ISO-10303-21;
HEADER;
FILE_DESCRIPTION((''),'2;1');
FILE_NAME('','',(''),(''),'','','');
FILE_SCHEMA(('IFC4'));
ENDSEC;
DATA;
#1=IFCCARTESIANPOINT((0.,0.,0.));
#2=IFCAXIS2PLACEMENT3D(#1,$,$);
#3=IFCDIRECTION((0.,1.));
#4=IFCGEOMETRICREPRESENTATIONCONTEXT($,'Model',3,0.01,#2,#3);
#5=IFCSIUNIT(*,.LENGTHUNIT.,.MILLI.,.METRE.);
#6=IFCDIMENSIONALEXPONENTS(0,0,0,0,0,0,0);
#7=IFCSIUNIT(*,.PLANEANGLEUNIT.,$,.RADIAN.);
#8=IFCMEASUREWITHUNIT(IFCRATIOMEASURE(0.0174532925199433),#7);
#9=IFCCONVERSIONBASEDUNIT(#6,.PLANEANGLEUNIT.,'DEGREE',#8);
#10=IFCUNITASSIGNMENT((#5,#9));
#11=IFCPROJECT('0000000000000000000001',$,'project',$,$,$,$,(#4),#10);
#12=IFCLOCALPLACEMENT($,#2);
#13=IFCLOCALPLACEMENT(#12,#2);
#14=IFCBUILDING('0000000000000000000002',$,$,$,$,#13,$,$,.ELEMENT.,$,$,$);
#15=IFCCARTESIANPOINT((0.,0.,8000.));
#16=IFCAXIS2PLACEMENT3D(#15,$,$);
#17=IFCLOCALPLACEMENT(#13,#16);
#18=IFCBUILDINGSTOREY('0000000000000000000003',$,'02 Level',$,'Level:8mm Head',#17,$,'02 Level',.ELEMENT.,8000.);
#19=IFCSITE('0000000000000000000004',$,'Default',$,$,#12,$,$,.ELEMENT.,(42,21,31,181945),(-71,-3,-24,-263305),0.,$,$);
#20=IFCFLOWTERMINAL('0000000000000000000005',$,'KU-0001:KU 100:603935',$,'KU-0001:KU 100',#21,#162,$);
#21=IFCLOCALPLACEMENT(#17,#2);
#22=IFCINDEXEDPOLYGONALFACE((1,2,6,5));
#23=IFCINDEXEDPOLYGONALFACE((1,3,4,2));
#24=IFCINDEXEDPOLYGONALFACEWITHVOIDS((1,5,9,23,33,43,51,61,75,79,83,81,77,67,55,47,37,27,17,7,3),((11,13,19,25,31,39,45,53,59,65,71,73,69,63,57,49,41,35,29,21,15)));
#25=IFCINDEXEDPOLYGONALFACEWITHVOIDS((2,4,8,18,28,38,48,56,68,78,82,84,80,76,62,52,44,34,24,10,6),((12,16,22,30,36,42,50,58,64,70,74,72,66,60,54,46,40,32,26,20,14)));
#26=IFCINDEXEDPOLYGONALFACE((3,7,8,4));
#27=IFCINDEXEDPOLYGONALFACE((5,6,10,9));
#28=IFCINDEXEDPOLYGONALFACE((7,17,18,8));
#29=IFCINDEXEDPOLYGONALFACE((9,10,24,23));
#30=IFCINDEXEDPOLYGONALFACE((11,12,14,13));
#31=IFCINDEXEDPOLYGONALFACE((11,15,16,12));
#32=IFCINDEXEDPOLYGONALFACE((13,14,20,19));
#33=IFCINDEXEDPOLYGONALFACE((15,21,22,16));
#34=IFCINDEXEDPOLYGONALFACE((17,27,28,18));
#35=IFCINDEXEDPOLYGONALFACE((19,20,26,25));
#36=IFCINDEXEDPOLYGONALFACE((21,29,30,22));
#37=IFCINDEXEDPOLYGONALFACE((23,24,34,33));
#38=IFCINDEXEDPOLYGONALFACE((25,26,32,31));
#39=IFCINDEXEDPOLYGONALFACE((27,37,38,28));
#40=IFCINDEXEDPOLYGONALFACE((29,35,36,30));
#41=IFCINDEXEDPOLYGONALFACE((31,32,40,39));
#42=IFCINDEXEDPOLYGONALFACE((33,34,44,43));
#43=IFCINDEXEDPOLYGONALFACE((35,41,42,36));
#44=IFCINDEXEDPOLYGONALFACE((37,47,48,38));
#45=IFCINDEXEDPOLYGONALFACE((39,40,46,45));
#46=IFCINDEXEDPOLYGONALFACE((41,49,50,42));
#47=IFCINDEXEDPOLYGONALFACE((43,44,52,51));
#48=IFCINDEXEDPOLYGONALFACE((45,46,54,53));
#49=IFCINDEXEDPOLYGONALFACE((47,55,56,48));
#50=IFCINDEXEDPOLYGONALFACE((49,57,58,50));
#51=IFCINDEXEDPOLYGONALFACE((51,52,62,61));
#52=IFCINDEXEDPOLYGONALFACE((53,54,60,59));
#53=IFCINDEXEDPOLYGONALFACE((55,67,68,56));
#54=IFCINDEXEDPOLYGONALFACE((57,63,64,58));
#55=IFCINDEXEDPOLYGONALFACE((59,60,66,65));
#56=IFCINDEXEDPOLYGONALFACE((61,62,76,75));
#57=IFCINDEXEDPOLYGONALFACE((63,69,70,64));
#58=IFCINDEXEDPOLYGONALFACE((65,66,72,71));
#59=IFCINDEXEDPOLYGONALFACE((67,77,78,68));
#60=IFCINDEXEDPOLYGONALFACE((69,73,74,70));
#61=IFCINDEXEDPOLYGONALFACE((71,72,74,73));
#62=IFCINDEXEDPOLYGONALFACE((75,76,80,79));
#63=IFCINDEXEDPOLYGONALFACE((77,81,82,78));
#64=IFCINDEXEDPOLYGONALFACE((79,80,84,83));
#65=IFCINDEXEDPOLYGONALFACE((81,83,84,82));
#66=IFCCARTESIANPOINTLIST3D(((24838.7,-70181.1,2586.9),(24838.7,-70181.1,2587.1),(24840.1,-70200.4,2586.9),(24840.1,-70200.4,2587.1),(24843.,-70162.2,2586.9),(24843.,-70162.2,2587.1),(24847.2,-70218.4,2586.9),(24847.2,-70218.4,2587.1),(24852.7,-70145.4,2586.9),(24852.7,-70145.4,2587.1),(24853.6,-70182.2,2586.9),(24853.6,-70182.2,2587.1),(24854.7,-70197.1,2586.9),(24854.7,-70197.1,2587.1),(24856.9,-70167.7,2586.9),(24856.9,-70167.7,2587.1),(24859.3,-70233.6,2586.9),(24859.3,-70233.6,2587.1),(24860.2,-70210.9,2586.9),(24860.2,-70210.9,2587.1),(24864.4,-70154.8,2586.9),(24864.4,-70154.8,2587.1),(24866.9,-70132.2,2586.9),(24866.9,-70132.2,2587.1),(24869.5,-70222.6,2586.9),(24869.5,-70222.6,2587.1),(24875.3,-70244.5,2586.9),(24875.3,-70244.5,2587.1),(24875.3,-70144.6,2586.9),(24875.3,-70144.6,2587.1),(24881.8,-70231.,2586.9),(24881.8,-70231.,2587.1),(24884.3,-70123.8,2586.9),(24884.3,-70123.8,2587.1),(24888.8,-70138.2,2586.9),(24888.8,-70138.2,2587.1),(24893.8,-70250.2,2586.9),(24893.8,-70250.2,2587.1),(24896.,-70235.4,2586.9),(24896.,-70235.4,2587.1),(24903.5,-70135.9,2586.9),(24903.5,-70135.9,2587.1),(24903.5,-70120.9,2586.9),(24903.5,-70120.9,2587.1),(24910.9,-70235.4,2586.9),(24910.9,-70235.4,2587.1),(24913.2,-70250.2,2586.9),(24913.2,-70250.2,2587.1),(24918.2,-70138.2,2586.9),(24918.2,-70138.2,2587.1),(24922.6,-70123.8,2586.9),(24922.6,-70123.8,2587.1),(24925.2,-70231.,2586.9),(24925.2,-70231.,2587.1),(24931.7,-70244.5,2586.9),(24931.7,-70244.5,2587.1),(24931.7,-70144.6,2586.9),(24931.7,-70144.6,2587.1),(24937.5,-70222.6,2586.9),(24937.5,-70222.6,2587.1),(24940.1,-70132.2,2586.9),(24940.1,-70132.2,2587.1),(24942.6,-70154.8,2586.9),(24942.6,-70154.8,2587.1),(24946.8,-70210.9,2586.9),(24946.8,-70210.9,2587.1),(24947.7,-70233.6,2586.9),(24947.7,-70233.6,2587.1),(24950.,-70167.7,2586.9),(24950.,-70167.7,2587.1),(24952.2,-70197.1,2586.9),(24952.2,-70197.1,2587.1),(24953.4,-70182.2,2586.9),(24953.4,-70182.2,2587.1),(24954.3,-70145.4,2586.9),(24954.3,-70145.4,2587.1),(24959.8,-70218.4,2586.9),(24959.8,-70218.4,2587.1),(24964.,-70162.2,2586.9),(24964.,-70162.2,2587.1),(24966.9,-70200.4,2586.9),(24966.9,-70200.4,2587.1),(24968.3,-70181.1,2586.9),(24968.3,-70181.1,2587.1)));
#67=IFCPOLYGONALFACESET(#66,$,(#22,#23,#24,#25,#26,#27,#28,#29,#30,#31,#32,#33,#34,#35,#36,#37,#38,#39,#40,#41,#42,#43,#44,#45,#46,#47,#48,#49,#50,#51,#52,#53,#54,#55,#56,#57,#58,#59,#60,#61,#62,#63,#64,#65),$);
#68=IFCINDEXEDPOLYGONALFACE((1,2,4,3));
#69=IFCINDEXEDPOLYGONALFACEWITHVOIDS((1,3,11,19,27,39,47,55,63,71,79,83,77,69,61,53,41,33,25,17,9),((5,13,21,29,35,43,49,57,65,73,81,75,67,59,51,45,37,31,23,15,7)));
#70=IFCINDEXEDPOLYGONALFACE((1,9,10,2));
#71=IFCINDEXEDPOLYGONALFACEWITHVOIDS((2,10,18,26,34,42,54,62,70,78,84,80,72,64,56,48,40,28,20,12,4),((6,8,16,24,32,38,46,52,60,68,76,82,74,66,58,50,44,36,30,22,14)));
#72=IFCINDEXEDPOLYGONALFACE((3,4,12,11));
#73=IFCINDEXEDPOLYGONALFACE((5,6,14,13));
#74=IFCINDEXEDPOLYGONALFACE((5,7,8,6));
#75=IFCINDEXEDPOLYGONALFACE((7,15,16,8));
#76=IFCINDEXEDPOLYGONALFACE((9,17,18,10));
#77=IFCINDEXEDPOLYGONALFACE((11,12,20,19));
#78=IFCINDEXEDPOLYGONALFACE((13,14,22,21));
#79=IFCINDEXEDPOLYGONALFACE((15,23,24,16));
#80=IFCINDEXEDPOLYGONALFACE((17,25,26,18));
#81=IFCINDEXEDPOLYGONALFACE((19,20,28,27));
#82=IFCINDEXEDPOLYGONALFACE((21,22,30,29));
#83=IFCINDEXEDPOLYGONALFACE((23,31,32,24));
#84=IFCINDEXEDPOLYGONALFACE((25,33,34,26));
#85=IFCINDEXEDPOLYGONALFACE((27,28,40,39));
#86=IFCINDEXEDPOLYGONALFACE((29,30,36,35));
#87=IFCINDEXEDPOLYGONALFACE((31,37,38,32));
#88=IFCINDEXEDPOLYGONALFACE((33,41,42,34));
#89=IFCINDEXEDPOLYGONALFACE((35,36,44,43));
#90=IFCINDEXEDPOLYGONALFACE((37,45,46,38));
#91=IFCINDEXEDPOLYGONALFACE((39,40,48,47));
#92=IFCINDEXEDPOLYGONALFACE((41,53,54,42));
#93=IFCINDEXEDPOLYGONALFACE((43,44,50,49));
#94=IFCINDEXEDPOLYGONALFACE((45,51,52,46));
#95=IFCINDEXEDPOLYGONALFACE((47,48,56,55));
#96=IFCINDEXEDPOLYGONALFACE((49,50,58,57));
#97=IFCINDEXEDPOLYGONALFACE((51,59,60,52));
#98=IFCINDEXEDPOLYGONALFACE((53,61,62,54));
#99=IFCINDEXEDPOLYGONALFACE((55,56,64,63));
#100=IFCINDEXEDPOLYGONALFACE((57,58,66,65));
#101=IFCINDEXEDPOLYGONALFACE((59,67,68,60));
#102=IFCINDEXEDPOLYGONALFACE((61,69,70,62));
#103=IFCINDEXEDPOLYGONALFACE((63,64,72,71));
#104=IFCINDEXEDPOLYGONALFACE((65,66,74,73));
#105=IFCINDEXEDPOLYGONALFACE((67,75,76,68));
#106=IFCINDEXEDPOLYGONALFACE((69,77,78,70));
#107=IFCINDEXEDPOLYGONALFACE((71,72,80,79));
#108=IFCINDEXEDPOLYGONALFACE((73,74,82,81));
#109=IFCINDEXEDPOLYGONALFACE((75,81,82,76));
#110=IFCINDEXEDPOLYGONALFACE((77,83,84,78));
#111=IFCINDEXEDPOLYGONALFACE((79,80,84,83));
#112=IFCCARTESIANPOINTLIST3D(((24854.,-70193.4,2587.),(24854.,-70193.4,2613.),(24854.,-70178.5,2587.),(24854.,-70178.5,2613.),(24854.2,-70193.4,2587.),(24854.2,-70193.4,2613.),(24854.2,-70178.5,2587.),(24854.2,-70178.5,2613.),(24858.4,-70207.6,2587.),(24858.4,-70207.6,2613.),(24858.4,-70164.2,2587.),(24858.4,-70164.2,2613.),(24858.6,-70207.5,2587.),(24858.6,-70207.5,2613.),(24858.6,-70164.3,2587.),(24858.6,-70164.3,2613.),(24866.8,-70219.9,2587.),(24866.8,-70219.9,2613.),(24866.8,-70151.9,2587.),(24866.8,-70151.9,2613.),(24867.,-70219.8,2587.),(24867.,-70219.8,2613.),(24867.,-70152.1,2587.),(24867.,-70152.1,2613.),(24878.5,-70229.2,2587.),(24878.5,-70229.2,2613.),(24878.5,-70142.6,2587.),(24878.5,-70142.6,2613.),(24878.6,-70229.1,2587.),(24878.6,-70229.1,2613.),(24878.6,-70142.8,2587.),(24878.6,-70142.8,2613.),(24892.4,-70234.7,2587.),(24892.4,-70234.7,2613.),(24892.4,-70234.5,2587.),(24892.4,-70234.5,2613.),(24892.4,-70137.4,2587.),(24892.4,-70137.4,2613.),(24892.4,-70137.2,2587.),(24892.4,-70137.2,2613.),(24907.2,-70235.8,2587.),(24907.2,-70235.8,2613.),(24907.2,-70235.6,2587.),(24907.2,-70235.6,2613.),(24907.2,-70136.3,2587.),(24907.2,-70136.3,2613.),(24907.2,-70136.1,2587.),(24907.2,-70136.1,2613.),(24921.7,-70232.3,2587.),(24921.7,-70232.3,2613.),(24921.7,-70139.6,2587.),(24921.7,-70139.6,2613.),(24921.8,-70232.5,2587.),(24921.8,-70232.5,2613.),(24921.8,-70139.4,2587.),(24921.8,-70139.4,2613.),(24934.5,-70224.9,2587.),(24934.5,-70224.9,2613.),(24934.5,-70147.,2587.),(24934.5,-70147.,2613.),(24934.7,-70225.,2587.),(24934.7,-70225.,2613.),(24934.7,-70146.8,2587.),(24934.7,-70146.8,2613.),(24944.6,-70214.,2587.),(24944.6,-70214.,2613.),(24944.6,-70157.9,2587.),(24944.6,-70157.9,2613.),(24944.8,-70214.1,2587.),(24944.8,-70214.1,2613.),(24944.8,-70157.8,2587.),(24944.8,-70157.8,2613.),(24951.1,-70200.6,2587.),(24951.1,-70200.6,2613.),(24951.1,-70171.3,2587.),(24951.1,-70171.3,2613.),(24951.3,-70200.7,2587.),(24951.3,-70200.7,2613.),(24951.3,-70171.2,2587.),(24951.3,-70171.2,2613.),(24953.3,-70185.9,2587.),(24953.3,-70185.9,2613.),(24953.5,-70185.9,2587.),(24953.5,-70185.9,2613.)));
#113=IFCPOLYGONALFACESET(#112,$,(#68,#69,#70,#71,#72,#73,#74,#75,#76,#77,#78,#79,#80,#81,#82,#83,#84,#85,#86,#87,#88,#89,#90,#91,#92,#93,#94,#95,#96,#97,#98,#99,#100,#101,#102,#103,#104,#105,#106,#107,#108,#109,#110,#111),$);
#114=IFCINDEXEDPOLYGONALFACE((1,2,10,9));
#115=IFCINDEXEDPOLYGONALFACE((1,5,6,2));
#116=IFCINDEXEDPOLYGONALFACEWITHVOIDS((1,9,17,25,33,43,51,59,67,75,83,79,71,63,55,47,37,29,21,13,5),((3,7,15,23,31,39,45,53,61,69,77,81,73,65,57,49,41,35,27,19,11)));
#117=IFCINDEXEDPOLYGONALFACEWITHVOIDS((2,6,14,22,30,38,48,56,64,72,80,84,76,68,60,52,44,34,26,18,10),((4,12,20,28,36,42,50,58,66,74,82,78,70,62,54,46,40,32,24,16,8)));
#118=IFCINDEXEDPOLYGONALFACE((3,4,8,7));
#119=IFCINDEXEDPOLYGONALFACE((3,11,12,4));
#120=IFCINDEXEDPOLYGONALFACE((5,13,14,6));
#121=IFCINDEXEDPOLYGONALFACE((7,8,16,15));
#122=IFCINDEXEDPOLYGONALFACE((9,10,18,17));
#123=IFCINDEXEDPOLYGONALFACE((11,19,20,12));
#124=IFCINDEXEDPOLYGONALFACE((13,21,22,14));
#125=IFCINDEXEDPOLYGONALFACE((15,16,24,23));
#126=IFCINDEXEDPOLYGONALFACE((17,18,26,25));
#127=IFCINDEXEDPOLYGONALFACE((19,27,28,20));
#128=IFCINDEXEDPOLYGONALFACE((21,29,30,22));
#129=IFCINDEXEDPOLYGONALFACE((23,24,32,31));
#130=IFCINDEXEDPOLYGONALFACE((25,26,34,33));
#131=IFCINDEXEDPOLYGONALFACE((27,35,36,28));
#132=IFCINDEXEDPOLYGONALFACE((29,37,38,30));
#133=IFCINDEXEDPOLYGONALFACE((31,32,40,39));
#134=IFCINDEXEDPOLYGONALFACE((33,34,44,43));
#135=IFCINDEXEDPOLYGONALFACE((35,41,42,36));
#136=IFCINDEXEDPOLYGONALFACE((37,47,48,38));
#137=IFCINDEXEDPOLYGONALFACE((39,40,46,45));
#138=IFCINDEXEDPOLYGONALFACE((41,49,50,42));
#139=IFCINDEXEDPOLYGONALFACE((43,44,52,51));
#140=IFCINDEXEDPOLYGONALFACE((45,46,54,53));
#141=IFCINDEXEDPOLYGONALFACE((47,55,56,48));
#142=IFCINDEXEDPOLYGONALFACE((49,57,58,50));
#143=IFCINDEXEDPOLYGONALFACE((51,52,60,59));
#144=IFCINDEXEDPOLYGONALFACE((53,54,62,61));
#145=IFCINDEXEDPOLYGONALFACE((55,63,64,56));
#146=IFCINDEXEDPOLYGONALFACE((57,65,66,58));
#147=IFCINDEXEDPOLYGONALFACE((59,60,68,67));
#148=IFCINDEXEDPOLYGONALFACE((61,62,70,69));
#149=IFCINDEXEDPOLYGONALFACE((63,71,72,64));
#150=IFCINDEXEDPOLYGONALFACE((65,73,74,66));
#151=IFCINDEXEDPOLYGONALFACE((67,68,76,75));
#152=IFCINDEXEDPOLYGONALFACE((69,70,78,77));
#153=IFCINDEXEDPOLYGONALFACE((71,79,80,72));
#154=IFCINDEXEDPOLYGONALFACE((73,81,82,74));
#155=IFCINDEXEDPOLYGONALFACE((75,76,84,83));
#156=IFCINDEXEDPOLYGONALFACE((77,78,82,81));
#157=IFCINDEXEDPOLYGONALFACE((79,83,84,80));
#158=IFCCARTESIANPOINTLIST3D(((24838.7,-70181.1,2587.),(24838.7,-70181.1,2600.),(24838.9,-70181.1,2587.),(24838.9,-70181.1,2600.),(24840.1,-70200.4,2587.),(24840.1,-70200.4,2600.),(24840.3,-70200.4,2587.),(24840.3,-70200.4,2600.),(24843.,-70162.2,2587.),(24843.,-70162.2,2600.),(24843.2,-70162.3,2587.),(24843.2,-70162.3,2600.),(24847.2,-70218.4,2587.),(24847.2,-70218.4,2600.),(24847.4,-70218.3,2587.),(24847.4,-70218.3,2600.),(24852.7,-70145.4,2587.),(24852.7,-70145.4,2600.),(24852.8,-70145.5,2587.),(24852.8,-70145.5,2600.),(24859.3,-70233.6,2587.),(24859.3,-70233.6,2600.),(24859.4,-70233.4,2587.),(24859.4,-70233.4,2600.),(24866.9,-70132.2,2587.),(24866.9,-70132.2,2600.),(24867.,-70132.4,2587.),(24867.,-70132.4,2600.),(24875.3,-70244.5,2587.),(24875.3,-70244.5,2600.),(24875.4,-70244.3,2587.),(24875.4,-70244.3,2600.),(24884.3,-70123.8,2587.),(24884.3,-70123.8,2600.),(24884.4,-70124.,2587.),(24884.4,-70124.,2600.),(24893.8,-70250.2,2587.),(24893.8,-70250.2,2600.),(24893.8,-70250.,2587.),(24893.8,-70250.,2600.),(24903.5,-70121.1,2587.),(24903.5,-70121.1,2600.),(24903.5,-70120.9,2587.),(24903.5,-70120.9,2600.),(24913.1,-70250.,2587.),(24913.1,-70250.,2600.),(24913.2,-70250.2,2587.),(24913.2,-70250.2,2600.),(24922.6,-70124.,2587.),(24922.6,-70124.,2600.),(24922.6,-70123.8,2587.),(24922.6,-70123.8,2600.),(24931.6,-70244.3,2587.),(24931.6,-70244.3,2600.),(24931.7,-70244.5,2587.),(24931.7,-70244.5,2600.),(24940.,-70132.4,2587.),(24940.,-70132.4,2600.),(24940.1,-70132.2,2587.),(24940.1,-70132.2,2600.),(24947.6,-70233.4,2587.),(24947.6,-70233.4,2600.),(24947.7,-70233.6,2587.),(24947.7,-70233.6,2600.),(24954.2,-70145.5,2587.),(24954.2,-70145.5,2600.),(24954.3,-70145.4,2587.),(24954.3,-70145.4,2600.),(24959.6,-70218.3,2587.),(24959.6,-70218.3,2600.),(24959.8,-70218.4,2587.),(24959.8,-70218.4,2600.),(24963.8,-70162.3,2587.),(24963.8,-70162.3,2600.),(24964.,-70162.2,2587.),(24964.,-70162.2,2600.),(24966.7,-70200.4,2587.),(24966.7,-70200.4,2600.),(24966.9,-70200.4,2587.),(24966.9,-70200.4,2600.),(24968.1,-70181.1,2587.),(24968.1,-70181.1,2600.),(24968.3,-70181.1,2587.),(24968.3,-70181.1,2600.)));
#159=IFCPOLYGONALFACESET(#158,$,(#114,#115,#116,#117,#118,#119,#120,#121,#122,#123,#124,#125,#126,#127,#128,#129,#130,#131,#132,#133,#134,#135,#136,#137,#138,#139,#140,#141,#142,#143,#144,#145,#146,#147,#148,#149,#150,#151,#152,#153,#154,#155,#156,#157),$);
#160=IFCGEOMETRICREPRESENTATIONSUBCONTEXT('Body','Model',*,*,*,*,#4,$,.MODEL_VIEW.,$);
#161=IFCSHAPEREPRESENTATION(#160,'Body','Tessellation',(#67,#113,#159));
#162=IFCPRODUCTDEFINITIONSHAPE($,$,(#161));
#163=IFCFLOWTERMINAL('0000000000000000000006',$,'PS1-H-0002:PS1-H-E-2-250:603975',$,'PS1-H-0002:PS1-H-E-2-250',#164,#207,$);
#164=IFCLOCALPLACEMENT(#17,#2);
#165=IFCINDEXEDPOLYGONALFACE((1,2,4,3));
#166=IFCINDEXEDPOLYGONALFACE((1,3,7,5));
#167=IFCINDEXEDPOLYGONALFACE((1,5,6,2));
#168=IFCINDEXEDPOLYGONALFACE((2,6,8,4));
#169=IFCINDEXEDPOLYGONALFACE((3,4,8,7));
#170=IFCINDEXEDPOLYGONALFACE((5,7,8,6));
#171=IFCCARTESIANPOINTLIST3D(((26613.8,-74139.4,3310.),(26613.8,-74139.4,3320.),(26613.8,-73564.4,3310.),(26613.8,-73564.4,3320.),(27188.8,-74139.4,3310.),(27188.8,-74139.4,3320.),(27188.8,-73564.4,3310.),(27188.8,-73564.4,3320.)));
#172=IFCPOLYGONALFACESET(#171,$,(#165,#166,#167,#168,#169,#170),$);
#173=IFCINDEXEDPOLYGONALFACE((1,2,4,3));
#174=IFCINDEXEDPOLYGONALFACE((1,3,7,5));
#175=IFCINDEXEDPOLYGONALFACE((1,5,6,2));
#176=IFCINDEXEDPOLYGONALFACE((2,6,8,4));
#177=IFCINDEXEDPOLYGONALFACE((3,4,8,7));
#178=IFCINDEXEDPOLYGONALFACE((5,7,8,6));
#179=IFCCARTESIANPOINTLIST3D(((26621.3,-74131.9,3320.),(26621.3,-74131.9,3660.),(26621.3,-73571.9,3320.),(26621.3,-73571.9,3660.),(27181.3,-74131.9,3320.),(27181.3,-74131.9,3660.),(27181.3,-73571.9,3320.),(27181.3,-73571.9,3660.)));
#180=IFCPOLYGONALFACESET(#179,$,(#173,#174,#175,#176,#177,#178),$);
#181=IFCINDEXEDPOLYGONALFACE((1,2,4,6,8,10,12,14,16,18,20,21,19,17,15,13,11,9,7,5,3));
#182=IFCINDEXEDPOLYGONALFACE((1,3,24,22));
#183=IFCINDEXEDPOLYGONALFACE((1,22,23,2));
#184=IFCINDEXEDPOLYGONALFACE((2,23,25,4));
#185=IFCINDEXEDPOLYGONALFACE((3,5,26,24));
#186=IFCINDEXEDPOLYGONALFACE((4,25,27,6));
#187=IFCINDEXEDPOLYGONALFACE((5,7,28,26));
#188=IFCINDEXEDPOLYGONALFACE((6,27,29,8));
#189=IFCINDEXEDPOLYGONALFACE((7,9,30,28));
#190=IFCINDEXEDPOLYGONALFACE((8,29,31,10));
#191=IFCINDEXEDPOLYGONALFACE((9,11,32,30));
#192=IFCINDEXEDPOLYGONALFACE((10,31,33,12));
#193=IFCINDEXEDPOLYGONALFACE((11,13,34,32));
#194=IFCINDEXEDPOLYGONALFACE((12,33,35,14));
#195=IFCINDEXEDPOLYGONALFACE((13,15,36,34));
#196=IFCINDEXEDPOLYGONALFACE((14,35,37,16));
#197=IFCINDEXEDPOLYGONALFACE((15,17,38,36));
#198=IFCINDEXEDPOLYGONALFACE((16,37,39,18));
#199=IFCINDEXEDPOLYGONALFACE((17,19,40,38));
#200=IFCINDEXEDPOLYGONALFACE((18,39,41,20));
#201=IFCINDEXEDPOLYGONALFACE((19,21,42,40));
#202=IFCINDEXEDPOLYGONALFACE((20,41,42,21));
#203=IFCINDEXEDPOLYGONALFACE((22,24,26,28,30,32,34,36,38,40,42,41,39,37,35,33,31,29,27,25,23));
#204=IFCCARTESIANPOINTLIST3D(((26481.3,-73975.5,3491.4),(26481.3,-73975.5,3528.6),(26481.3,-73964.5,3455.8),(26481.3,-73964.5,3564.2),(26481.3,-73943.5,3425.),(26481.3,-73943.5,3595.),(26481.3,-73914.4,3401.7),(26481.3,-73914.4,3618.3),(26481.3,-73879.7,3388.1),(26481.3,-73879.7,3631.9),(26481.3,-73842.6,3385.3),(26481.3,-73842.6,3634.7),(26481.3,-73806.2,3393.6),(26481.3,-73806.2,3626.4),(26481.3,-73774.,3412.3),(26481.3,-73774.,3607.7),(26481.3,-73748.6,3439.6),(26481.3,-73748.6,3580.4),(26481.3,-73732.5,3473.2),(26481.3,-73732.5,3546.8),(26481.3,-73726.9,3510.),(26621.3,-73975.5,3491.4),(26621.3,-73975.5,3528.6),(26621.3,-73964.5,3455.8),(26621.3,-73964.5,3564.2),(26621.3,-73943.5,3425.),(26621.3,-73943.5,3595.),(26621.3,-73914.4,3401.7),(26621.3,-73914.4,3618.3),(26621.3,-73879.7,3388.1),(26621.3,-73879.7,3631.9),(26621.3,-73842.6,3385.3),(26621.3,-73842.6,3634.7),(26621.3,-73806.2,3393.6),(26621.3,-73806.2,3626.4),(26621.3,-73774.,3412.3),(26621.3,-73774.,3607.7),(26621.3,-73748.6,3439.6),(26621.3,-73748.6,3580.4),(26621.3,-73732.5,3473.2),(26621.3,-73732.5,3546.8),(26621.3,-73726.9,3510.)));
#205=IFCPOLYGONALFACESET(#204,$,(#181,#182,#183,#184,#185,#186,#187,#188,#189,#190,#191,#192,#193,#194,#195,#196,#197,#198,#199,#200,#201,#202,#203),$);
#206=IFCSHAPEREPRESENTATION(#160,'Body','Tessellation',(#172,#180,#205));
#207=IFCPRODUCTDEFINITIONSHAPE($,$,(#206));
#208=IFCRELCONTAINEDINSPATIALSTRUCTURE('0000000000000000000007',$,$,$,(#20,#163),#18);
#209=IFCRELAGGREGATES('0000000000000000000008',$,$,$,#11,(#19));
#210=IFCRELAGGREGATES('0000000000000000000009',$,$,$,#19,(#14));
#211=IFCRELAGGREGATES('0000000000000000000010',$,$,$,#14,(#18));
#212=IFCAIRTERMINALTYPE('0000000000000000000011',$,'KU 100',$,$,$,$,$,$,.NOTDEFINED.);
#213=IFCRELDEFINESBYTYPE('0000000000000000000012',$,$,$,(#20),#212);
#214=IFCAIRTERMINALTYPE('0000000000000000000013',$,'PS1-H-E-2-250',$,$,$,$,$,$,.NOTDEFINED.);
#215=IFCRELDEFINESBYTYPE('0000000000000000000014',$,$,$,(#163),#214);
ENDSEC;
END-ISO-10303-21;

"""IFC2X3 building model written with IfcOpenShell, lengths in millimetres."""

from ifc_helpers import new_model, entity, si_unit, converted_unit, direction, frame, frame_2d, origin, origin_2d_with_axis, place, context, subcontext, project, spatial, rectangle, circle, hollow_circle, extrude, source, transform, mapped, type_object, type_shapes, element, save


model = new_model("IFC2X3")

# Units and contexts
model_context = context("Model", 3, precision=0.01, world=origin(), true_north=direction((0.0, 1.0)))
body_context = subcontext(model_context, "Body", "Model", "MODEL_VIEW")
ifc_project = project(units=[si_unit("LENGTHUNIT", "METRE", prefix="MILLI"), converted_unit("PLANEANGLEUNIT", "DEGREE", entity("IfcRatioMeasure", 0.0174532925199433), si_unit("PLANEANGLEUNIT", "RADIAN"), dimensions=[0, 0, 0, 0, 0, 0, 0])], contexts=[model_context])

# Site, building, storey
site_placement = place(None, origin())
site = spatial("IfcSite", under=ifc_project, at=site_placement, Name="Default", CompositionType="ELEMENT", RefLatitude=(42, 21, 31, 181945), RefLongitude=(-71, -3, -24, -263305), RefElevation=0.0)
building_placement = place(site_placement, origin())
building = spatial("IfcBuilding", under=site, at=building_placement, CompositionType="ELEMENT")
storey_placement = place(building_placement, frame((0.0, 0.0, 8000.0)))
storey = spatial("IfcBuildingStorey", under=building, at=storey_placement, Name="02 Level", ObjectType="Level:8mm Head", LongName="02 Level", CompositionType="ELEMENT", Elevation=8000.0)

# Flow terminals
air_terminal_type_1 = type_object("IfcAirTerminalType", Name="KU 100", PredefinedType="NOTDEFINED")
shared_shape_1 = source(origin(), body_context, "Body", "SweptSolid", [
    extrude(hollow_circle(Radius=65.0, WallThickness=15.0, at=frame_2d((0.0, 0.0), x_axis=(1.0, 0.0))), frame((12.9, 0.0, 0.0), z_axis=(1.0, 0.0, 0.0), x_axis=(0.0, 1.0, 0.0)), (0.0, 0.0, 1.0), 0.2),
    extrude(hollow_circle(Radius=50.0, WallThickness=0.2, at=frame_2d((0.0, 0.0), x_axis=(1.0, 0.0))), frame((-13.0, 0.0, 0.0), z_axis=(1.0, 0.0, 0.0), x_axis=(0.0, 0.0, 1.0)), (0.0, 0.0, 1.0), 26.0),
    extrude(hollow_circle(Radius=65.0, WallThickness=0.2, at=frame_2d((0.0, 0.0), x_axis=(1.0, 0.0))), frame((0.0, 0.0, 0.0), z_axis=(1.0, 0.0, 0.0), x_axis=(0.0, 1.0, 0.0)), (0.0, 0.0, 1.0), 13.0),
])
type_shapes(air_terminal_type_1, [shared_shape_1])
flow_terminal_1_placement = place(storey_placement, frame((24903.5, -70185.9, 2600.0), z_axis=(1.0, 0.0, 0.0), x_axis=(0.0, 0.0, -1.0)))
element("IfcFlowTerminal", 1, at=flow_terminal_1_placement, inside=storey, type_object=air_terminal_type_1, Name="KU-0001:KU 100:603935", ObjectType="KU-0001:KU 100", context=body_context, shape_type="MappedRepresentation", body=[
    mapped(shared_shape_1, transform((0.0, 0.0, 0.0), scale=1.0)),
])
air_terminal_type_2 = type_object("IfcAirTerminalType", Name="PS1-H-E-2-250", PredefinedType="NOTDEFINED")
shared_shape_2 = source(origin(), body_context, "Body", "SweptSolid", [
    extrude(rectangle(XDim=575.0, YDim=575.0, at=origin_2d_with_axis()), frame((0.0, 0.0, -10.0), z_axis=(0.0, 0.0, 1.0), x_axis=(-1.0, 0.0, 0.0)), (0.0, 0.0, 1.0), 10.0),
    extrude(rectangle(XDim=560.0, YDim=560.0, at=origin_2d_with_axis()), frame((0.0, 0.0, 0.0), z_axis=(0.0, 0.0, 1.0), x_axis=(-1.0, 0.0, 0.0)), (0.0, 0.0, 1.0), 340.0),
    extrude(circle(Radius=125.0, at=frame_2d((0.0, 0.0), x_axis=(1.0, 0.0))), frame((-420.0, 0.0, 190.0), z_axis=(1.0, 0.0, 0.0), x_axis=(0.0, 1.0, 0.0)), (0.0, 0.0, 1.0), 140.0),
])
type_shapes(air_terminal_type_2, [shared_shape_2])
flow_terminal_2_placement = place(storey_placement, frame((26901.3, -73851.9, 3320.0)))
element("IfcFlowTerminal", 2, at=flow_terminal_2_placement, inside=storey, type_object=air_terminal_type_2, Name="PS1-H-0002:PS1-H-E-2-250:603975", ObjectType="PS1-H-0002:PS1-H-E-2-250", context=body_context, shape_type="MappedRepresentation", body=[
    mapped(shared_shape_2, transform((0.0, 0.0, 0.0), scale=1.0)),
])

save(model, "model.ifc")
